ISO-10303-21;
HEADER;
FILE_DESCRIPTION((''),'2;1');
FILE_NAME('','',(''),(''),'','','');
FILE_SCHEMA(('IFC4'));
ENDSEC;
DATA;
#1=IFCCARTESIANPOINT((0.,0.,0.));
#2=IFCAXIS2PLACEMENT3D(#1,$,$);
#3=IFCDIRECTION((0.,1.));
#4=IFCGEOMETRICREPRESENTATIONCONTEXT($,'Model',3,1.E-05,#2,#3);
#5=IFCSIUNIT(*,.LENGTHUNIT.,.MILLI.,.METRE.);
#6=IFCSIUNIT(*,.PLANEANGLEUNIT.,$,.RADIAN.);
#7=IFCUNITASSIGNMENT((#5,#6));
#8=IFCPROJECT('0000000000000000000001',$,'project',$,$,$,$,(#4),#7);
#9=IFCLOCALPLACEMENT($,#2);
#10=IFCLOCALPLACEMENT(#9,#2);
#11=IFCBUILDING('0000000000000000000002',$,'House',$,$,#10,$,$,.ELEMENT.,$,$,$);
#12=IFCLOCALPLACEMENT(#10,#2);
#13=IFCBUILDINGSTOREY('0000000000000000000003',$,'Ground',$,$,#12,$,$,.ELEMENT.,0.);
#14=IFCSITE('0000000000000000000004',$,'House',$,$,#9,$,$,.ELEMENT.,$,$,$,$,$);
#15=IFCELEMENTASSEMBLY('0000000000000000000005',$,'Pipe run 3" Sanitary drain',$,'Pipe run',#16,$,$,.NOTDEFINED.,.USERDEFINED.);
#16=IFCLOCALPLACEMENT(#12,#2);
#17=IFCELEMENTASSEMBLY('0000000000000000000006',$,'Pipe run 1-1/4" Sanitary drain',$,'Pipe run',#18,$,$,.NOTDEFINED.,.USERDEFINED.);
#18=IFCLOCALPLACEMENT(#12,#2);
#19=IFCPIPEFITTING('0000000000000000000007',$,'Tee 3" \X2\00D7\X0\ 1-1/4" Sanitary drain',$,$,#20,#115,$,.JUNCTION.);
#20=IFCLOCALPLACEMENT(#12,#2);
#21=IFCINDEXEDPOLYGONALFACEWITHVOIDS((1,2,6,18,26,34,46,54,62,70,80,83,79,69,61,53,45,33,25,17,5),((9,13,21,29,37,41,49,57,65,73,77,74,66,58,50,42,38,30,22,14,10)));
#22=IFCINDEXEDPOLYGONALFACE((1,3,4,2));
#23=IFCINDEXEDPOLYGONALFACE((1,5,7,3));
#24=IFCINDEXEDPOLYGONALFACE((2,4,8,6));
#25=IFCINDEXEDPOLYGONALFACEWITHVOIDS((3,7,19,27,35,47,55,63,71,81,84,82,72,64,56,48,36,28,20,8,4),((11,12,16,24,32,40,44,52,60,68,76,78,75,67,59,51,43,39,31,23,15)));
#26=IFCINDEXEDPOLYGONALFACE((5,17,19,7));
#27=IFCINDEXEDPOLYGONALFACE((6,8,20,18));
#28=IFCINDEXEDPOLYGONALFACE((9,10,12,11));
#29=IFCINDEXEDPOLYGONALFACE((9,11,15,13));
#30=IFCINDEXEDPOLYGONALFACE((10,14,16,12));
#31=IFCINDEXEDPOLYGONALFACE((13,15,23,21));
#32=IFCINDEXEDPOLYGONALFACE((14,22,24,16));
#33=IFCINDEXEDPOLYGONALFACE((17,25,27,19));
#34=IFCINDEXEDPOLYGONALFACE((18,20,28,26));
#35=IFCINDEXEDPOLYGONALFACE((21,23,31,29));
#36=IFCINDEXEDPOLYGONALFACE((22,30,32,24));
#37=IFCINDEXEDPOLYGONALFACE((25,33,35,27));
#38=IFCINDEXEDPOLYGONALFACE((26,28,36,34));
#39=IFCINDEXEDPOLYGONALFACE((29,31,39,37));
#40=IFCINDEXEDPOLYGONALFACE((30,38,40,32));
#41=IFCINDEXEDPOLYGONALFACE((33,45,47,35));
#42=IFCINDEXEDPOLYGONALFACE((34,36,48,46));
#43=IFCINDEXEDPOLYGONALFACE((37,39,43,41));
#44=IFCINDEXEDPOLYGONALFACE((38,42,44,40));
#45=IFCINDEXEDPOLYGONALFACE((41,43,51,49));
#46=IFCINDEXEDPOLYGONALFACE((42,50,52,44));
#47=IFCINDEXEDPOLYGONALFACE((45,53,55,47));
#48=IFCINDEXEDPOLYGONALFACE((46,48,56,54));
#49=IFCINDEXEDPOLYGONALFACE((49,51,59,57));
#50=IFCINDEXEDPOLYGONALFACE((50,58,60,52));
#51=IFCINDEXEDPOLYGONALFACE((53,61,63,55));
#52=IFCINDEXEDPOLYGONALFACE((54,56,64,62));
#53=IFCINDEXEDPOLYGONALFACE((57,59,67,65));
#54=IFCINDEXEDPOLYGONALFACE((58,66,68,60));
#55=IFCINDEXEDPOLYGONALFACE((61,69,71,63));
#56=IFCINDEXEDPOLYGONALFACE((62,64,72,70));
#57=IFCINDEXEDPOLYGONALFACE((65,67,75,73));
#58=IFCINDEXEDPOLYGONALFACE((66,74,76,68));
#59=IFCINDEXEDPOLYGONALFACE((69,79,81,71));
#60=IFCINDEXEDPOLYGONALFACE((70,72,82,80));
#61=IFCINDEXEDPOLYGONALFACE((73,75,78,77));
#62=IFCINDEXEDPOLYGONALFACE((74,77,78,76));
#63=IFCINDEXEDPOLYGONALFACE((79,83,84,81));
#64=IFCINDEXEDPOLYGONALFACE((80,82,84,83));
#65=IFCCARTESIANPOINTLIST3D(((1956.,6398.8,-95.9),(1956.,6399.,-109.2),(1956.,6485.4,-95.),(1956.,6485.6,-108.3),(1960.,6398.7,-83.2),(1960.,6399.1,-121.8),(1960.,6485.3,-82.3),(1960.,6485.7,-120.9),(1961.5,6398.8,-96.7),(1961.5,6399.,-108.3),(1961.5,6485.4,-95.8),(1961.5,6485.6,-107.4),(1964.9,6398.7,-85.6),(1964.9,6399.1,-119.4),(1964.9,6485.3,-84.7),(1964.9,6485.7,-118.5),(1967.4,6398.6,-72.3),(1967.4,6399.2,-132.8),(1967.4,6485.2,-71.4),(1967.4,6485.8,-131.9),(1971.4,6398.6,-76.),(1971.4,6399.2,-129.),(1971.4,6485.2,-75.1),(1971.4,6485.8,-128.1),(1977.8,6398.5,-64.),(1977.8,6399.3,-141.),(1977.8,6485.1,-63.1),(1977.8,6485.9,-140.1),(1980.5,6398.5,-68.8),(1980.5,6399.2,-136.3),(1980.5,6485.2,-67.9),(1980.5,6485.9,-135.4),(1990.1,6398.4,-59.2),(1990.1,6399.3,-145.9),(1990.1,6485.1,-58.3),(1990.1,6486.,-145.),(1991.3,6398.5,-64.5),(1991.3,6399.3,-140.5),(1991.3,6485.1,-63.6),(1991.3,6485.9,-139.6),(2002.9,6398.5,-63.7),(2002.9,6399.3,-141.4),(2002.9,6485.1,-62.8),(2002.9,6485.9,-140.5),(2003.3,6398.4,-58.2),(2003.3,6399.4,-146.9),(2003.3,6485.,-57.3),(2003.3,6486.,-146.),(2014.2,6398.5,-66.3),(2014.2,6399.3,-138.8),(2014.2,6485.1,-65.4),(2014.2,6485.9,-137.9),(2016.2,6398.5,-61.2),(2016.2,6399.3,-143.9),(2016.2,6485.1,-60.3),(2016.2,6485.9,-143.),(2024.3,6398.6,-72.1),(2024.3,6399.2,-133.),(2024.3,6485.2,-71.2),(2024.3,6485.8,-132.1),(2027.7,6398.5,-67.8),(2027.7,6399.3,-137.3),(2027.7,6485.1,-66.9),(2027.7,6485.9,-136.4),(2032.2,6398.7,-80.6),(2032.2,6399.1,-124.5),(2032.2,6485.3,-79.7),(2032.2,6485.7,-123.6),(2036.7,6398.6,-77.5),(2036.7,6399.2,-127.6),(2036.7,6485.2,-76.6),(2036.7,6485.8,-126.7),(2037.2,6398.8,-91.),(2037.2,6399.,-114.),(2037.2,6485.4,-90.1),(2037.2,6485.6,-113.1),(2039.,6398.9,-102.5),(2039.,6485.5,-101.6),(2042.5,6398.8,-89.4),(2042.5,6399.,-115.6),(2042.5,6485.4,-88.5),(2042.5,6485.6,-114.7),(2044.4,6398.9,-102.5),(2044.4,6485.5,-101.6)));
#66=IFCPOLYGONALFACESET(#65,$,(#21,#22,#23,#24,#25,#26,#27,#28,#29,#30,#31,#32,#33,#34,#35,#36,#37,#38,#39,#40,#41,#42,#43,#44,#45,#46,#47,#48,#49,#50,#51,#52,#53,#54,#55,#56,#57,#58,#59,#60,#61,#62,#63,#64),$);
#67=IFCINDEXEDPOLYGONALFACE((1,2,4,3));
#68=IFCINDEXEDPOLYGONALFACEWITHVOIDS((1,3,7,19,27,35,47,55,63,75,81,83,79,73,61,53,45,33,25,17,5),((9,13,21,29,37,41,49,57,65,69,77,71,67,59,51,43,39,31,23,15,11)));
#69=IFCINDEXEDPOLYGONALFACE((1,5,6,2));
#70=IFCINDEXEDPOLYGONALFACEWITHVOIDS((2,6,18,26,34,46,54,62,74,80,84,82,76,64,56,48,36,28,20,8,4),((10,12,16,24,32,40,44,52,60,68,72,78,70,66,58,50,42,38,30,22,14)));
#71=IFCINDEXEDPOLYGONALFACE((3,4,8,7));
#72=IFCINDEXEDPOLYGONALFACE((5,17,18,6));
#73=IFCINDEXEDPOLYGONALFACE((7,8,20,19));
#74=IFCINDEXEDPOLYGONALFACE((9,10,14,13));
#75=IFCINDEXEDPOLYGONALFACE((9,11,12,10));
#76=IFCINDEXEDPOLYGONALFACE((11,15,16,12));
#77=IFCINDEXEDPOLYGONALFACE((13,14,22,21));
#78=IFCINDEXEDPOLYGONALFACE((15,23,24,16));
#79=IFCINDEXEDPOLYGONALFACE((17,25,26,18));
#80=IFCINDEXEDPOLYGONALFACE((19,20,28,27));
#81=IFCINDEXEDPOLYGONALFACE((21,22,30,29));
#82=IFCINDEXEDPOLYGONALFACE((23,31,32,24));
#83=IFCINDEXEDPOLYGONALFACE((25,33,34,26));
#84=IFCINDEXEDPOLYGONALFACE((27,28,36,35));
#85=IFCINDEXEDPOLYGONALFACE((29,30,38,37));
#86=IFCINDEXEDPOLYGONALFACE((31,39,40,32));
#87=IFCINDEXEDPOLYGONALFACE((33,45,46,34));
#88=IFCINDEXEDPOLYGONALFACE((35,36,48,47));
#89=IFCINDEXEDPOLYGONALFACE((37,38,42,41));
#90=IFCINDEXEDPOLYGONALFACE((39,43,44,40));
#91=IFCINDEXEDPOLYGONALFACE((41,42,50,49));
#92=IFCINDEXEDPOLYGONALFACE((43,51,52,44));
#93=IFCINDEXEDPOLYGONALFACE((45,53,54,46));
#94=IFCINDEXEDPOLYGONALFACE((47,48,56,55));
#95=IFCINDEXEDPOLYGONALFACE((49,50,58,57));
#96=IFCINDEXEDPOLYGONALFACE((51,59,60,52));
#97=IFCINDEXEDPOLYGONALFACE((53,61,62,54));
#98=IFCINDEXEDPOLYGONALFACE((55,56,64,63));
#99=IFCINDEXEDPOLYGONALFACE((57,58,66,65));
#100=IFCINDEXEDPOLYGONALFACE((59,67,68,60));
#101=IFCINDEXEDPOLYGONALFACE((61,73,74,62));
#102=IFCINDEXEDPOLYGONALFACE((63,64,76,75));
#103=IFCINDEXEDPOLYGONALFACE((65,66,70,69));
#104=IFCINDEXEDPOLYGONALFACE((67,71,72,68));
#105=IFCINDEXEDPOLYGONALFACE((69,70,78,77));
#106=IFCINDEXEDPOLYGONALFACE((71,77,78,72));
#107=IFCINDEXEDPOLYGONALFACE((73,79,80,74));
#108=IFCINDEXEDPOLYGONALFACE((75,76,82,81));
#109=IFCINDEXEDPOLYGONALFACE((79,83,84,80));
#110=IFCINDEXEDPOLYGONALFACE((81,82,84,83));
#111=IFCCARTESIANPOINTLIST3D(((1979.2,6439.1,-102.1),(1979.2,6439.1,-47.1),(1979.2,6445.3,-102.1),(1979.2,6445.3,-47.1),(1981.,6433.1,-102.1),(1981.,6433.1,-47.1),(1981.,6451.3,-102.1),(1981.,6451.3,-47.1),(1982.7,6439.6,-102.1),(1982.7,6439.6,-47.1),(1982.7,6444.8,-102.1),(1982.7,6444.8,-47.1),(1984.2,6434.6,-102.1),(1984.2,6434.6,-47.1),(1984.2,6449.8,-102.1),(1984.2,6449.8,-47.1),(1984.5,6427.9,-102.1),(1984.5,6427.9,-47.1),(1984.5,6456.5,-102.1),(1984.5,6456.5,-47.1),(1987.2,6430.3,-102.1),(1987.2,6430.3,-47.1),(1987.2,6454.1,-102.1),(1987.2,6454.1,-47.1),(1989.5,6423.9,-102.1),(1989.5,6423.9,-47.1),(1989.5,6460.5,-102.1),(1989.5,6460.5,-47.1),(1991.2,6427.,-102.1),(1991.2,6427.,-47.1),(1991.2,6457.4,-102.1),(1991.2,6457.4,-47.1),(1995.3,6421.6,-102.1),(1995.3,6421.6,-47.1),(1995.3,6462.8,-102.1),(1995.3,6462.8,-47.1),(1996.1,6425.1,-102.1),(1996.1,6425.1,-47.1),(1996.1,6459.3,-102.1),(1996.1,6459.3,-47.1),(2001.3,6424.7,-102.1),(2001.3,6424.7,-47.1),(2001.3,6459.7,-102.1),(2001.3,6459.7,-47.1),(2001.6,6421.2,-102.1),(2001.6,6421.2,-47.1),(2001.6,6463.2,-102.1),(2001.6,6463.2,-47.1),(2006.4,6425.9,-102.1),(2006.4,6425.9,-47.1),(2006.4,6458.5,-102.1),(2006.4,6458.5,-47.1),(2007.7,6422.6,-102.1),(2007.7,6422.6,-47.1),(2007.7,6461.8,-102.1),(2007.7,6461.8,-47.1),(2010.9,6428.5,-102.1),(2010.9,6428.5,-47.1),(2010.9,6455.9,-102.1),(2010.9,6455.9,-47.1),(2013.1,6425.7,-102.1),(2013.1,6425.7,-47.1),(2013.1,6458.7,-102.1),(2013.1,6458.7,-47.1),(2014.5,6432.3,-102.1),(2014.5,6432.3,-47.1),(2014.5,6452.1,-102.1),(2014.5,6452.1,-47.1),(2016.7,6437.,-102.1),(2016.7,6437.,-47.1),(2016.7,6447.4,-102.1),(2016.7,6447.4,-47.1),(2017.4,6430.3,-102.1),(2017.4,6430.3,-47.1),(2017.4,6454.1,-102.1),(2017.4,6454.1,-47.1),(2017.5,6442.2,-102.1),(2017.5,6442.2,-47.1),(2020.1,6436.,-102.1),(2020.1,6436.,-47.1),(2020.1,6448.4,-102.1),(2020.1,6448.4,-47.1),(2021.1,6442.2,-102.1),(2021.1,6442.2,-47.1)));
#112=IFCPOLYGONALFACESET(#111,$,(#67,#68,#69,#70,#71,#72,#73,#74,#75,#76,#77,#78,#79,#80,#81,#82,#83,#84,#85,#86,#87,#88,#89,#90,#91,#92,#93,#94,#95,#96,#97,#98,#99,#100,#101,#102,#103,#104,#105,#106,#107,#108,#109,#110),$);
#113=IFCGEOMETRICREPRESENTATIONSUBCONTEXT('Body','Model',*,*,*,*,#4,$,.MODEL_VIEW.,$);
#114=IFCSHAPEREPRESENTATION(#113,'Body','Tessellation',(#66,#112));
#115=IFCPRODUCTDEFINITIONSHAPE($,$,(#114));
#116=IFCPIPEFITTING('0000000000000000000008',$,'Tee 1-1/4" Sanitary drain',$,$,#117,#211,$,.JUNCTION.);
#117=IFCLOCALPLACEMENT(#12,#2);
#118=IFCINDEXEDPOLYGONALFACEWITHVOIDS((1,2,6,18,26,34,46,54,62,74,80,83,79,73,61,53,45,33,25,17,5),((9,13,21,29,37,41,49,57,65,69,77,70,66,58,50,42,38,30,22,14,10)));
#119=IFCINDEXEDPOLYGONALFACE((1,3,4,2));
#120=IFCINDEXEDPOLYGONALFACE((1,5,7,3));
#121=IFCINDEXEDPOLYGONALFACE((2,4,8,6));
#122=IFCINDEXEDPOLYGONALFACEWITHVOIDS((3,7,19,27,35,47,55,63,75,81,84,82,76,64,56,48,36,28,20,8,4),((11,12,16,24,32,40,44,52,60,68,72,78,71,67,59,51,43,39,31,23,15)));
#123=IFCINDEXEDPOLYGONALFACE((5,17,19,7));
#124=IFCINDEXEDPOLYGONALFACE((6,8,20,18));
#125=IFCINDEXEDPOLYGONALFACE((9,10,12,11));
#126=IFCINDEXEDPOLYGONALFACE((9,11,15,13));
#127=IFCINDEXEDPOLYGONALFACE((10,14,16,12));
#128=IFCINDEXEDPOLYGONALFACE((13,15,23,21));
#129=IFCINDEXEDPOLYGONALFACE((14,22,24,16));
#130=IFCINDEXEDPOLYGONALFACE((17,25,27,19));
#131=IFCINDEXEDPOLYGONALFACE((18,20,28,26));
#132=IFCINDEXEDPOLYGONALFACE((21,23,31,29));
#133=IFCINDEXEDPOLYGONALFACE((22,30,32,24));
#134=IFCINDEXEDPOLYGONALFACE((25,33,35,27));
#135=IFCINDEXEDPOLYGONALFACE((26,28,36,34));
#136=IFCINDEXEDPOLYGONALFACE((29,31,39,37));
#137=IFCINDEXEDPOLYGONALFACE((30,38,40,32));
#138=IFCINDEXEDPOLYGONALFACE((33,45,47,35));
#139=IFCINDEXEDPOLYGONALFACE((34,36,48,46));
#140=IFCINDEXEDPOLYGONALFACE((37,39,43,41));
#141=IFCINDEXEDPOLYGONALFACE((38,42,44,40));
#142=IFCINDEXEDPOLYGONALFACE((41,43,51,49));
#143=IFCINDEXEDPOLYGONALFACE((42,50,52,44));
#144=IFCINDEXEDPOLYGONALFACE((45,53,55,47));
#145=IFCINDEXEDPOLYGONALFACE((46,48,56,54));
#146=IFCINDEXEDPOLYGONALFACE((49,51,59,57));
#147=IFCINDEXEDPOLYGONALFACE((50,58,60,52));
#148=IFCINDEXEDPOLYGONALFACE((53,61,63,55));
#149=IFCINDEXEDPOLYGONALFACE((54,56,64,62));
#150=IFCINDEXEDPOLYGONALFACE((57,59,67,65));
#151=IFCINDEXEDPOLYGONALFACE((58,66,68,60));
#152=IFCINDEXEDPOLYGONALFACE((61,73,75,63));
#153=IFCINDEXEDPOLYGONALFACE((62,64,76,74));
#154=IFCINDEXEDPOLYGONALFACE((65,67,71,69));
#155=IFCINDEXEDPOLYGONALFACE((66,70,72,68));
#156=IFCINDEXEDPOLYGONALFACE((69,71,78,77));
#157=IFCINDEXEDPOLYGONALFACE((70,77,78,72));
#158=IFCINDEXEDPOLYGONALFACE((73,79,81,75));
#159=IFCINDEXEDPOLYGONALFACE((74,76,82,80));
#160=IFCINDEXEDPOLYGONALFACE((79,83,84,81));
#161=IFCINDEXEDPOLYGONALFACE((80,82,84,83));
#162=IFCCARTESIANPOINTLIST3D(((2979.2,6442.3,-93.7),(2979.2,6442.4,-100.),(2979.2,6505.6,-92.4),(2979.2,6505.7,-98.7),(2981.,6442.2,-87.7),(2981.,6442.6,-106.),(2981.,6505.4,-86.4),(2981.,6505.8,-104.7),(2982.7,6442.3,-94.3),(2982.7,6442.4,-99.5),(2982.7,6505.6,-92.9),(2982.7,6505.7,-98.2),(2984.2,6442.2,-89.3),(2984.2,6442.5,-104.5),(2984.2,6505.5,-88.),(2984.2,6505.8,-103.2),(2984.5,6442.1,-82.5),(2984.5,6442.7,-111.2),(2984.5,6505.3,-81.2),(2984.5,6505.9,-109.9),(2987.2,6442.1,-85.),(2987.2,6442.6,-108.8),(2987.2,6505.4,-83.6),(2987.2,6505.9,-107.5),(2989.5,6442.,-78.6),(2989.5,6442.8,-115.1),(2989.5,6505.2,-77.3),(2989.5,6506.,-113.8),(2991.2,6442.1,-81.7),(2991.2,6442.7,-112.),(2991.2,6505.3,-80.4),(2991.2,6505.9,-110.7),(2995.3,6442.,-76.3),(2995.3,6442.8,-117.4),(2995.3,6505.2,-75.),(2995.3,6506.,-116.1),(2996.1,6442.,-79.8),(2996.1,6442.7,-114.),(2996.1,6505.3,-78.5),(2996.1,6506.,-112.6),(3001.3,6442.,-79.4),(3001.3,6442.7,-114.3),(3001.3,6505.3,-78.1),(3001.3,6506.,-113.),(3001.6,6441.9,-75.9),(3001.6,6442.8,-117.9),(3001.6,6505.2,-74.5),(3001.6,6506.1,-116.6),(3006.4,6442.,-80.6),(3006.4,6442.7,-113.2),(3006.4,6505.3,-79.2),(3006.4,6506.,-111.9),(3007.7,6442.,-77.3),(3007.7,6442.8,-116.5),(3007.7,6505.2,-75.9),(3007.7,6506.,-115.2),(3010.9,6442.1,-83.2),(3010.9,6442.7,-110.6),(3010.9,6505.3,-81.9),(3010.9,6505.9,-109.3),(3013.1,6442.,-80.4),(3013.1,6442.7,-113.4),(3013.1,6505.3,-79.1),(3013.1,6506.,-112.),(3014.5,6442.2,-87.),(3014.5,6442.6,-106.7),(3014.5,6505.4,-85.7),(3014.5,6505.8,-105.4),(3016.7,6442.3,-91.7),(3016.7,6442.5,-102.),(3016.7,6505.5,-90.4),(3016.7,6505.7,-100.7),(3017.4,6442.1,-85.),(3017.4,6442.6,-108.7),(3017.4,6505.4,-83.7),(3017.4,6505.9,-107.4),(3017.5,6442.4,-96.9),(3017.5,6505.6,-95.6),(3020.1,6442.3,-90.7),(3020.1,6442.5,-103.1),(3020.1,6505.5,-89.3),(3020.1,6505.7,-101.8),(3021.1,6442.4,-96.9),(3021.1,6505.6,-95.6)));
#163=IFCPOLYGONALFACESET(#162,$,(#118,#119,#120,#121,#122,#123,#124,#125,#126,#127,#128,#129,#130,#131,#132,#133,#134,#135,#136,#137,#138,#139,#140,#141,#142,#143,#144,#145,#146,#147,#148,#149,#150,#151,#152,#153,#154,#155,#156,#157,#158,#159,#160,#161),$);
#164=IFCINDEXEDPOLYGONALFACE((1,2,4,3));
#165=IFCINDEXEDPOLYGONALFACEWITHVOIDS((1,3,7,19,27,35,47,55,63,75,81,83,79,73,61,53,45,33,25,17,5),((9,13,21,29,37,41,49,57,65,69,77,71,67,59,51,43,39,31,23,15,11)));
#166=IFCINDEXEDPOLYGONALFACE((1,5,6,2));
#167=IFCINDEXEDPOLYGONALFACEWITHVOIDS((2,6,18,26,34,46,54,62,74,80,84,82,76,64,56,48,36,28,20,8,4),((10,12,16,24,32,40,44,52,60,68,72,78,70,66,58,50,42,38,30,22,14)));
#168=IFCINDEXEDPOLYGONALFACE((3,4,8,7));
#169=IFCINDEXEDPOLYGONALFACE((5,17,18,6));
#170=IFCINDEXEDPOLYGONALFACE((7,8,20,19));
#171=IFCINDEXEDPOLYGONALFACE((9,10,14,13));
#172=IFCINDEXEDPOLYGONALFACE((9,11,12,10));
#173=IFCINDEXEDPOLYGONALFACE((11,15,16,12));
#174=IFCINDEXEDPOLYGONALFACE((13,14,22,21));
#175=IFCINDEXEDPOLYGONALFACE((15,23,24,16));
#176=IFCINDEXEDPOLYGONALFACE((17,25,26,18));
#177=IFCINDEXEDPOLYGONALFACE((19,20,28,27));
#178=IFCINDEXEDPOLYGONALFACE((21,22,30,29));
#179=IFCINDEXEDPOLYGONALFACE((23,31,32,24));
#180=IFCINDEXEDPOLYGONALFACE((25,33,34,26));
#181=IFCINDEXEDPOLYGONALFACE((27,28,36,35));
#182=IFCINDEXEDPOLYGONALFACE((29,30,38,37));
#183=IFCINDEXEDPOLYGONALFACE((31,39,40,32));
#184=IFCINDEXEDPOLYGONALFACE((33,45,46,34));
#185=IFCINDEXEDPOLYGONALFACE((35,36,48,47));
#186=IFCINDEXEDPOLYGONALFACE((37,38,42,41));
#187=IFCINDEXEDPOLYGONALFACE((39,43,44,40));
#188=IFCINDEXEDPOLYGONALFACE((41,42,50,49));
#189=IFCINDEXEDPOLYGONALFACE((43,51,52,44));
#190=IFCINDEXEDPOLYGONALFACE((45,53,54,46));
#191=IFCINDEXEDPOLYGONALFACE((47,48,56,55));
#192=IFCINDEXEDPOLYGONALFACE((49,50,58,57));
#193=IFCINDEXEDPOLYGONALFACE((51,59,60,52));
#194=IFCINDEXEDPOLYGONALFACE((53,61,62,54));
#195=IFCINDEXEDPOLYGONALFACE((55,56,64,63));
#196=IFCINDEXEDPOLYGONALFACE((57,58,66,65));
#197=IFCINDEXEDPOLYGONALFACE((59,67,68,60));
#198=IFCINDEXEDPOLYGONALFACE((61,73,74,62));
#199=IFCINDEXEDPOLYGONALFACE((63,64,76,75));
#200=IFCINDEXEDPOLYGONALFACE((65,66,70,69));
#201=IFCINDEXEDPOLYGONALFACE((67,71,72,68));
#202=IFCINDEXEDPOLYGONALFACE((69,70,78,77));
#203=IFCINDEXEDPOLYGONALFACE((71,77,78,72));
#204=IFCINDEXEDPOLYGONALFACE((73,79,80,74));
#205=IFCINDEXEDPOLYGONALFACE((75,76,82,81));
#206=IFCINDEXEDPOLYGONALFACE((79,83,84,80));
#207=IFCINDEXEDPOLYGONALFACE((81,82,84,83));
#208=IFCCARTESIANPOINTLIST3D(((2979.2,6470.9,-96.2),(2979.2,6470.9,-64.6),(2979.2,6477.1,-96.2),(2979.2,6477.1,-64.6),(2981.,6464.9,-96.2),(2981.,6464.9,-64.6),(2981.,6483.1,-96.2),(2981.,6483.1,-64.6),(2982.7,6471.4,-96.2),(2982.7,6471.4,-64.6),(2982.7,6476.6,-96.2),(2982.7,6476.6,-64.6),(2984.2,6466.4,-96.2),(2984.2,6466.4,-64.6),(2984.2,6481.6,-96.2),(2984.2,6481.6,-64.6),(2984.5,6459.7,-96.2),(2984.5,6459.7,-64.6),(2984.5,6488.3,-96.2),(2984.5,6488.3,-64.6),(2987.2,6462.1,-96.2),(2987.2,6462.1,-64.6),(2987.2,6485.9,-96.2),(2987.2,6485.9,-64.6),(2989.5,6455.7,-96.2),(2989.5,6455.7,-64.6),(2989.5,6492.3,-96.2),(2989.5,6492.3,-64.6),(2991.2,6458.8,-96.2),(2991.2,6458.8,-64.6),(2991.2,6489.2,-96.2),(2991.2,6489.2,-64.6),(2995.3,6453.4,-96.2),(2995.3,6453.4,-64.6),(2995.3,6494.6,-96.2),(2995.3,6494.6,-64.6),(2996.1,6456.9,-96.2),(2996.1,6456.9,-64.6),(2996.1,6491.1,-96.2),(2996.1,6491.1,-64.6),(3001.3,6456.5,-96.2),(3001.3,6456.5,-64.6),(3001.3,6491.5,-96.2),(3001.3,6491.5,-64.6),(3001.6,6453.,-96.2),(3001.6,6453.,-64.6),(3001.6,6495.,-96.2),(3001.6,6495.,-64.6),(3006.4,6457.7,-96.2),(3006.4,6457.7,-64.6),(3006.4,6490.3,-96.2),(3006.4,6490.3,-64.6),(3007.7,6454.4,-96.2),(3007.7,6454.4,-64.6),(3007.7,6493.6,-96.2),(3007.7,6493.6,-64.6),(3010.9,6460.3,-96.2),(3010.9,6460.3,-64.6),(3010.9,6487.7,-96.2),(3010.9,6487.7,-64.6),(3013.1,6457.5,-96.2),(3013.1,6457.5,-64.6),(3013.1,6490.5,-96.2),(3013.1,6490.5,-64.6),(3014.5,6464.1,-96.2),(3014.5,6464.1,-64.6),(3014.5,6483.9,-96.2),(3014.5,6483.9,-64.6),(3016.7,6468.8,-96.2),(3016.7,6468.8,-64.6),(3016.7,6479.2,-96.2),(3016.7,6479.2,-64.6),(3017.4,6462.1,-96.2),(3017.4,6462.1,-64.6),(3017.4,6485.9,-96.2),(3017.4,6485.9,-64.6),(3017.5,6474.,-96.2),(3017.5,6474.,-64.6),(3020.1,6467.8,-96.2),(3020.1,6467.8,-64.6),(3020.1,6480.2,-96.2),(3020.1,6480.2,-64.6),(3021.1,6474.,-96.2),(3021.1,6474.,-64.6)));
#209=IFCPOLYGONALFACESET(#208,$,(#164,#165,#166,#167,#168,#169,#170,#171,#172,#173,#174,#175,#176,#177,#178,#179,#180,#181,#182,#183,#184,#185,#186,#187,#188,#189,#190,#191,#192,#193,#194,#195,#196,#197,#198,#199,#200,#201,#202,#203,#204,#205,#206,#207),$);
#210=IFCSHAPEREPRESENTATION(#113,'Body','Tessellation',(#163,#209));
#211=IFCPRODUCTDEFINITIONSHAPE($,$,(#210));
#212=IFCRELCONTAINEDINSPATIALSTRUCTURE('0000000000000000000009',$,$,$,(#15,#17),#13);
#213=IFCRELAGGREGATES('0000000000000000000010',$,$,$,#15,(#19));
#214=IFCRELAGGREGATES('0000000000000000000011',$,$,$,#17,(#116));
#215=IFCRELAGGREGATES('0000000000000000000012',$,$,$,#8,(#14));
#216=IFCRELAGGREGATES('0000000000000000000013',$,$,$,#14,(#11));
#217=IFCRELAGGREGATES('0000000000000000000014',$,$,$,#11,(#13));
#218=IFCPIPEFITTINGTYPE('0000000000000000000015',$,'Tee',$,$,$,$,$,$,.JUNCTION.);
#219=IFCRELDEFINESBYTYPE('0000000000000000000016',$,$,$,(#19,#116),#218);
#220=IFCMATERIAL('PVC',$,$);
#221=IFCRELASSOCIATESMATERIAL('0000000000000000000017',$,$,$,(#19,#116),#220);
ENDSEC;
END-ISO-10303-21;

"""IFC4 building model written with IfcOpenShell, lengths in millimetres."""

from ifc_helpers import new_model, si_unit, direction, frame, origin, origin_with_axes, origin_2d, place, context, subcontext, project, spatial, hollow_circle, extrude, material, type_object, element, aggregate, save


model = new_model("IFC4")

# Units and contexts
model_context = context("Model", 3, precision=1e-05, world=origin(), true_north=direction((0.0, 1.0)))
body_context = subcontext(model_context, "Body", "Model", "MODEL_VIEW")
ifc_project = project(units=[si_unit("LENGTHUNIT", "METRE", prefix="MILLI"), si_unit("PLANEANGLEUNIT", "RADIAN")], contexts=[model_context])

# Site, building, storey
site_placement = place(None, origin())
site = spatial("IfcSite", under=ifc_project, at=site_placement, Name="House", CompositionType="ELEMENT")
building_placement = place(site_placement, origin())
building = spatial("IfcBuilding", under=site, at=building_placement, Name="House", CompositionType="ELEMENT")
storey_placement = place(building_placement, origin())
storey = spatial("IfcBuildingStorey", under=building, at=storey_placement, Name="Ground", CompositionType="ELEMENT", Elevation=0.0)

# Shared definitions
ifc_material = material(Name="PVC")

# Element assembly
assembly_1_placement = place(storey_placement, origin_with_axes())
assembly_1 = element("IfcElementAssembly", 1, at=assembly_1_placement, inside=storey, Name="Pipe run 3\" Sanitary drain", ObjectType="Pipe run", AssemblyPlace="NOTDEFINED", PredefinedType="USERDEFINED")

# Element assembly
assembly_2_placement = place(storey_placement, origin_with_axes())
assembly_2 = element("IfcElementAssembly", 2, at=assembly_2_placement, inside=storey, Name="Pipe run 1-1/4\" Sanitary drain", ObjectType="Pipe run", AssemblyPlace="NOTDEFINED", PredefinedType="USERDEFINED")

# Pipe fittings
pipe_fitting_type_1 = type_object("IfcPipeFittingType", Name="Tee", PredefinedType="JUNCTION")
pipe_fitting_1_placement = place(storey_placement, origin_with_axes())
pipe_fitting_1 = element("IfcPipeFitting", 3, at=pipe_fitting_1_placement, type_object=pipe_fitting_type_1, material=ifc_material, Name="Tee 3\" × 1-1/4\" Sanitary drain", PredefinedType="JUNCTION", context=body_context, shape_type="SweptSolid", body=[
    extrude(hollow_circle(Radius=44.5, WallThickness=5.5, at=origin_2d()), frame((2000.0, 6485.5, -101.6), z_axis=(0.0, -0.999946, -0.010416), x_axis=(1.0, 0.0, 0.0)), (0.0, 0.0, 1.0), 86.6),
    extrude(hollow_circle(Radius=21.1, WallThickness=3.6, at=origin_2d()), frame((2000.0, 6442.2, -102.1), z_axis=(0.0, 0.0, 1.0), x_axis=(1.0, 0.0, 0.0)), (0.0, 0.0, 1.0), 55.0),
])
aggregate(assembly_1, [pipe_fitting_1])
pipe_fitting_2_placement = place(storey_placement, origin_with_axes())
pipe_fitting_2 = element("IfcPipeFitting", 4, at=pipe_fitting_2_placement, type_object=pipe_fitting_type_1, material=ifc_material, Name="Tee 1-1/4\" Sanitary drain", PredefinedType="JUNCTION", context=body_context, shape_type="SweptSolid", body=[
    extrude(hollow_circle(Radius=21.1, WallThickness=3.6, at=origin_2d()), frame((3000.0, 6505.6, -95.6), z_axis=(0.0, -0.999783, -0.020829), x_axis=(1.0, 0.0, 0.0)), (0.0, 0.0, 1.0), 63.2),
    extrude(hollow_circle(Radius=21.1, WallThickness=3.6, at=origin_2d()), frame((3000.0, 6474.0, -96.2), z_axis=(0.0, 0.0, 1.0), x_axis=(1.0, 0.0, 0.0)), (0.0, 0.0, 1.0), 31.6),
])
aggregate(assembly_2, [pipe_fitting_2])

save(model, "model.ifc")
